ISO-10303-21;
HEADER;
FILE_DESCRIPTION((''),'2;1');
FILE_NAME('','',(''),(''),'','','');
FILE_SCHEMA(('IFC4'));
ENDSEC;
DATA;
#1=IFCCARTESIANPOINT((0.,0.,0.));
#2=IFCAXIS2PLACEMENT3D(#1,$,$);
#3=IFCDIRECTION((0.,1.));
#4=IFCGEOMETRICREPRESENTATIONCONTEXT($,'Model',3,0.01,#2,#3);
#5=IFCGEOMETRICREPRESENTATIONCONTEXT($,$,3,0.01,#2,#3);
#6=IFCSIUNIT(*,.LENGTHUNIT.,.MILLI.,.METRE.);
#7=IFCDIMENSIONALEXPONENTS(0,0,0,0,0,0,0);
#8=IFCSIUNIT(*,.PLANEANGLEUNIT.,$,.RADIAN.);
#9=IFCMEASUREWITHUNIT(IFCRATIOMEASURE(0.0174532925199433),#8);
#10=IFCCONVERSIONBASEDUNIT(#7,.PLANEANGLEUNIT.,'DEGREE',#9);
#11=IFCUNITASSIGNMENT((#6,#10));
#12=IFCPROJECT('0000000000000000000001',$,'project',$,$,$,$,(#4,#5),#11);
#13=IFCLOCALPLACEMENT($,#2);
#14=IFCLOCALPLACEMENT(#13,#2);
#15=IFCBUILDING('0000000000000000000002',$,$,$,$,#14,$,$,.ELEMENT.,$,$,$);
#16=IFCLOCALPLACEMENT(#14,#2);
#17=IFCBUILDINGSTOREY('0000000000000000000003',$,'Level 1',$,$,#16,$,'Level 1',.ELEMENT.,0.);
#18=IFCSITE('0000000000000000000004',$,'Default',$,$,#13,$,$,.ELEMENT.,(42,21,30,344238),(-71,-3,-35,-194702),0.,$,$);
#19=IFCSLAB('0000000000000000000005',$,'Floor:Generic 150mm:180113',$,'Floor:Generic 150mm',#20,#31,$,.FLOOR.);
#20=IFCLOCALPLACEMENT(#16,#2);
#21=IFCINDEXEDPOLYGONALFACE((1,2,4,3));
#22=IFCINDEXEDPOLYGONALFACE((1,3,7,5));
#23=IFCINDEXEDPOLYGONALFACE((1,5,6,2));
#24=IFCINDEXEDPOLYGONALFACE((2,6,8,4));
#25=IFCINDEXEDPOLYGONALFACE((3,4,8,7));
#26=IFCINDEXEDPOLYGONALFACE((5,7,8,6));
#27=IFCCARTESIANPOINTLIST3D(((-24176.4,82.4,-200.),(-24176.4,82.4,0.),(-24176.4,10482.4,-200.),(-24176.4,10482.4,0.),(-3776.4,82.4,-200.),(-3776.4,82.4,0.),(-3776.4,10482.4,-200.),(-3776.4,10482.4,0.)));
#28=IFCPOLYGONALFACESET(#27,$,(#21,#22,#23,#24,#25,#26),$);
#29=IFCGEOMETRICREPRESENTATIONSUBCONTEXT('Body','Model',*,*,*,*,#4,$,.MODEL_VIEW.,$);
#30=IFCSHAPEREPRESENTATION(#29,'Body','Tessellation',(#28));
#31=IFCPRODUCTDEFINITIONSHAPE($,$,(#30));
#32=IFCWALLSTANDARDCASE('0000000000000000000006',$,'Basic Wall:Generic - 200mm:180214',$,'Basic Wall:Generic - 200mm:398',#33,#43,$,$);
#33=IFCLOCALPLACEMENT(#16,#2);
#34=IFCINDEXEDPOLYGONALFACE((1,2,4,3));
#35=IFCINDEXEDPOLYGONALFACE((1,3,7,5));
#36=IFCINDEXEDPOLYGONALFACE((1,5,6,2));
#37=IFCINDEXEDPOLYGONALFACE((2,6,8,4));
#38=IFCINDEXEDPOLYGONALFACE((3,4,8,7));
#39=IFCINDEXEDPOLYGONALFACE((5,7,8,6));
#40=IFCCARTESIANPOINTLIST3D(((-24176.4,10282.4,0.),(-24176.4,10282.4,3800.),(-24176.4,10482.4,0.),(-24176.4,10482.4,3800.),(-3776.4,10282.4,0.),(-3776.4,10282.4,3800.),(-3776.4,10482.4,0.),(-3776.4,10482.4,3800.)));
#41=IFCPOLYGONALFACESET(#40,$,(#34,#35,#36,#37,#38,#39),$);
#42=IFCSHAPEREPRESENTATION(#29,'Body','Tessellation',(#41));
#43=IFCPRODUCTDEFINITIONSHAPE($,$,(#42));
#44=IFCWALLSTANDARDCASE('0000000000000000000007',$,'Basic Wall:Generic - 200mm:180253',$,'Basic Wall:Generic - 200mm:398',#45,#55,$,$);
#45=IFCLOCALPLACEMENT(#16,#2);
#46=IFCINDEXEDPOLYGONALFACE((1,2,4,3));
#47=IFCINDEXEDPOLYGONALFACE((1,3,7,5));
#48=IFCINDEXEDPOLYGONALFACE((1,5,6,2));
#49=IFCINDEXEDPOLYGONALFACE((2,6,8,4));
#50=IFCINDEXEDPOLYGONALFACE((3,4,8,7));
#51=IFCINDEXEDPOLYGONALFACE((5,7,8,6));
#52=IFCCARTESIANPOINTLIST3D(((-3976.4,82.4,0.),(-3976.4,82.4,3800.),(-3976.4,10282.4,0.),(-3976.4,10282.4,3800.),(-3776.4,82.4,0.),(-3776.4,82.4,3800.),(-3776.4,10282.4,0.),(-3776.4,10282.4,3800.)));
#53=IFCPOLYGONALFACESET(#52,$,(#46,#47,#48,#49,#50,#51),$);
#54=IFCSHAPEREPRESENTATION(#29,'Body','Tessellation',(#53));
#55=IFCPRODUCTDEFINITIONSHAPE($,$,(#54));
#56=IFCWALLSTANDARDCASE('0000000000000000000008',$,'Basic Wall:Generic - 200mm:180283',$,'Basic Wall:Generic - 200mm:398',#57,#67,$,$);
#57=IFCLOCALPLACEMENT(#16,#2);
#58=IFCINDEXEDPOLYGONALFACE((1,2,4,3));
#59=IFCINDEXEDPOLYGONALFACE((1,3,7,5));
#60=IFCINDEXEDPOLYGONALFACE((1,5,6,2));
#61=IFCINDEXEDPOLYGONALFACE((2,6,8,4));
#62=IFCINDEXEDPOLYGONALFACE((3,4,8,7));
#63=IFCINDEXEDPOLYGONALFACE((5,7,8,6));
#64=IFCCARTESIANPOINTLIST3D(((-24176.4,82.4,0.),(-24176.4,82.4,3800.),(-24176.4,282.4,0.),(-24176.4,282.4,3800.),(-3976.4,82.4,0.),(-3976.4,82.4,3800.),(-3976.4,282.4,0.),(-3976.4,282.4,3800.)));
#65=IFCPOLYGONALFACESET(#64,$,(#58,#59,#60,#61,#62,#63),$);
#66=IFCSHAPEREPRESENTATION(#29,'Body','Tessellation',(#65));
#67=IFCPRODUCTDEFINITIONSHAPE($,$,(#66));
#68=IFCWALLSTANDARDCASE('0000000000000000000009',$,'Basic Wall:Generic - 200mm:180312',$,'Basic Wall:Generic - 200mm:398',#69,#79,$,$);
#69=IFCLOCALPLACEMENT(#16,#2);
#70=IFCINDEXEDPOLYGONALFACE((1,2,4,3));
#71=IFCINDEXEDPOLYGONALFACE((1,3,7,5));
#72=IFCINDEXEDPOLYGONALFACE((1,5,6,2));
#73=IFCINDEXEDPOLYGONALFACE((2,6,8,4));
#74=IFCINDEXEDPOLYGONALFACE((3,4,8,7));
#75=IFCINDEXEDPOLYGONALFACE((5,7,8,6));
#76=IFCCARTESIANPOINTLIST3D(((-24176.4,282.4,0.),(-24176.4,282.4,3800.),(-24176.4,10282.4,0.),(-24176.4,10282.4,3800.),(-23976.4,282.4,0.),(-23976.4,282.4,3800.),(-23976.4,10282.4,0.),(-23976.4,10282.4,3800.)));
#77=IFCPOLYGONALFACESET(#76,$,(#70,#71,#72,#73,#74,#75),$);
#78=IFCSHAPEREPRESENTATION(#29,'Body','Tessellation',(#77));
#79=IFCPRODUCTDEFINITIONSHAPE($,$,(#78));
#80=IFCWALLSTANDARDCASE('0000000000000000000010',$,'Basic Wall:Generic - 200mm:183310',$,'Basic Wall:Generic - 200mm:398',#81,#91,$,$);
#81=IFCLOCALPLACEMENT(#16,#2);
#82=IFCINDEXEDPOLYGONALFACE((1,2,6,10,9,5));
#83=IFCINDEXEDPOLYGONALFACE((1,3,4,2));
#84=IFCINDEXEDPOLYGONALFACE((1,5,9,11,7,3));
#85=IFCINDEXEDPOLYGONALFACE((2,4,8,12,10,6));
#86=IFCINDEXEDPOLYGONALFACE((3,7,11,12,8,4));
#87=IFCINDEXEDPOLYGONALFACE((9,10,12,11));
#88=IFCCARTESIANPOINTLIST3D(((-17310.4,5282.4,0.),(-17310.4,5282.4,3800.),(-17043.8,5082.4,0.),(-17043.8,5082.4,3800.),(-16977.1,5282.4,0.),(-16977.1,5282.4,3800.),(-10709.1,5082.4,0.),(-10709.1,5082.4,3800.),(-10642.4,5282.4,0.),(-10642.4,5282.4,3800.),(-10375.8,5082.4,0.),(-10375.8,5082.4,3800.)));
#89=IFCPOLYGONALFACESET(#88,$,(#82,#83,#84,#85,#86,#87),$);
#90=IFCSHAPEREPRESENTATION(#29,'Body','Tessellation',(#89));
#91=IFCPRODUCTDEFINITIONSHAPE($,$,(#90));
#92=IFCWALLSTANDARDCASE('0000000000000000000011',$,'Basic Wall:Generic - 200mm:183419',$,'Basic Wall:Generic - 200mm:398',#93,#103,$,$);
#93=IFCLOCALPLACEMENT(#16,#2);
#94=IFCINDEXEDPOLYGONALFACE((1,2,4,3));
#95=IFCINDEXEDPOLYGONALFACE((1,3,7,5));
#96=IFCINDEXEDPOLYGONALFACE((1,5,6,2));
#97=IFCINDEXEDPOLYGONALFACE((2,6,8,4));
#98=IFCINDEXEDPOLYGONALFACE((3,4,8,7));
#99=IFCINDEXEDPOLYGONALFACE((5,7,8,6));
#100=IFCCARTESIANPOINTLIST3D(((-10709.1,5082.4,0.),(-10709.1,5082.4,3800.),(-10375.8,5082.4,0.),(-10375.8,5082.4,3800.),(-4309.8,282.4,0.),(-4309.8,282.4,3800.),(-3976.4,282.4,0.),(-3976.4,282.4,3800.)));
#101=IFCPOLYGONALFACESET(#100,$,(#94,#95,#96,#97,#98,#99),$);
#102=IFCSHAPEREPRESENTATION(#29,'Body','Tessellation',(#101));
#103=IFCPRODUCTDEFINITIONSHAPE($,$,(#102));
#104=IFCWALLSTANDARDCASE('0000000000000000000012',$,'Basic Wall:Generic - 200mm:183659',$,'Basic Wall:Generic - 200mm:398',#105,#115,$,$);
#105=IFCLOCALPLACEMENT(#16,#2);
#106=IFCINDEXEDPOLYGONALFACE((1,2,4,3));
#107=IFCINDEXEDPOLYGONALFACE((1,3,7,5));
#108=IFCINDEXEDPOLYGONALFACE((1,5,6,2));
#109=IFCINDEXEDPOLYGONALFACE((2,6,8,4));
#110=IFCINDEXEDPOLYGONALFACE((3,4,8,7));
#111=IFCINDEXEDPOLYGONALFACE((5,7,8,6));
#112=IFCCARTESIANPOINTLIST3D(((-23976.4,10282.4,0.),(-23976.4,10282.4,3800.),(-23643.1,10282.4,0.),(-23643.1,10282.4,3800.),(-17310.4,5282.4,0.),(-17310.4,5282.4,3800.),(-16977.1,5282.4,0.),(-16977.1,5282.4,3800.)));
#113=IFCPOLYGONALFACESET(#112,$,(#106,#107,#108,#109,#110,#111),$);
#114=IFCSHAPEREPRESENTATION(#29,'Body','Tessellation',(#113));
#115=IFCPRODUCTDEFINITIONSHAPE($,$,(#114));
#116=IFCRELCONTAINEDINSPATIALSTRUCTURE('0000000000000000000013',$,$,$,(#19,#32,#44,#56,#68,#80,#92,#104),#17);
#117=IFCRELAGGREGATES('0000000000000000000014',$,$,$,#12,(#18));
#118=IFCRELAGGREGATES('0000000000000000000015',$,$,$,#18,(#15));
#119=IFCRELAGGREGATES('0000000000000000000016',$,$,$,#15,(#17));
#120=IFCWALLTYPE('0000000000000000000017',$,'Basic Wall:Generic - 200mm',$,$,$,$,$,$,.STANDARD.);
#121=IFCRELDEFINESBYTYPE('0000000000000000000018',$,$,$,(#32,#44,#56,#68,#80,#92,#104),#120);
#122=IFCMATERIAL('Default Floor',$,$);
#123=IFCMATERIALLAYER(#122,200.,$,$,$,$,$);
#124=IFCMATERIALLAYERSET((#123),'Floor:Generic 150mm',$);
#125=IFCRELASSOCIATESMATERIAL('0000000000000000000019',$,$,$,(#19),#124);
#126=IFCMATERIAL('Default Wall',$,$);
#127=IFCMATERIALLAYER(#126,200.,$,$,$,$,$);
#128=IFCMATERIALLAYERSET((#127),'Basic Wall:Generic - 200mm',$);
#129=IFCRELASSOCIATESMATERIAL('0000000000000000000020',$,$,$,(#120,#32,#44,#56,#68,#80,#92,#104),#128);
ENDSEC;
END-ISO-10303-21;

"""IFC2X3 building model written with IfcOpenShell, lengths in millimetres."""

from ifc_helpers import new_model, entity, si_unit, converted_unit, direction, frame, frame_2d, origin, origin_2d_with_axis, place, context, subcontext, project, spatial, polyline, rectangle, outline, extrude, material, layer, layer_set, layer_usage, type_object, element, save


model = new_model("IFC2X3")

# Units and contexts
model_context = context("Model", 3, precision=0.01, world=origin(), true_north=direction((0.0, 1.0)))
context_of_model = context(None, 3, precision=0.01, world=origin(), true_north=direction((0.0, 1.0)))
body_context = subcontext(model_context, "Body", "Model", "MODEL_VIEW")
ifc_project = project(units=[si_unit("LENGTHUNIT", "METRE", prefix="MILLI"), converted_unit("PLANEANGLEUNIT", "DEGREE", entity("IfcRatioMeasure", 0.0174532925199433), si_unit("PLANEANGLEUNIT", "RADIAN"), dimensions=[0, 0, 0, 0, 0, 0, 0])], contexts=[model_context, context_of_model])

# Site, building, storey
site_placement = place(None, origin())
site = spatial("IfcSite", under=ifc_project, at=site_placement, Name="Default", CompositionType="ELEMENT", RefLatitude=(42, 21, 30, 344238), RefLongitude=(-71, -3, -35, -194702), RefElevation=0.0)
building_placement = place(site_placement, origin())
building = spatial("IfcBuilding", under=site, at=building_placement, CompositionType="ELEMENT")
storey_placement = place(building_placement, origin())
storey = spatial("IfcBuildingStorey", under=building, at=storey_placement, Name="Level 1", LongName="Level 1", CompositionType="ELEMENT", Elevation=0.0)

# Slab
ifc_material_1 = material(Name="Default Floor")
ifc_layer_1 = layer(ifc_material_1, 200.0)
ifc_layer_set_1 = layer_set([ifc_layer_1], Name="Floor:Generic 150mm")
ifc_layer_usage_1 = layer_usage(ifc_layer_set_1, "AXIS3", "POSITIVE", 0.0)
slab_placement = place(storey_placement, origin())
element("IfcSlab", 1, at=slab_placement, inside=storey, material=ifc_layer_usage_1, Name="Floor:Generic 150mm:180113", ObjectType="Floor:Generic 150mm", PredefinedType="FLOOR", context=body_context, shape_type="SweptSolid", body=[
    extrude(rectangle(XDim=10400.0, YDim=20400.0, at=origin_2d_with_axis()), frame((-13976.4, 5282.4, 0.0), z_axis=(0.0, 0.0, -1.0), x_axis=(0.0, 1.0, 0.0)), (0.0, 0.0, 1.0), 200.0),
])

# Walls
ifc_material_2 = material(Name="Default Wall")
ifc_layer_2 = layer(ifc_material_2, 200.0)
ifc_layer_set_2 = layer_set([ifc_layer_2], Name="Basic Wall:Generic - 200mm")
ifc_layer_usage_2 = layer_usage(ifc_layer_set_2, "AXIS2", "NEGATIVE", 100.0)
wall_type = type_object("IfcWallType", Name="Basic Wall:Generic - 200mm", PredefinedType="STANDARD", material=ifc_layer_set_2)
wall_1_placement = place(storey_placement, frame((-24176.4, 10382.4, 0.0)))
element("IfcWallStandardCase", 2, at=wall_1_placement, inside=storey, type_object=wall_type, material=ifc_layer_usage_2, Name="Basic Wall:Generic - 200mm:180214", ObjectType="Basic Wall:Generic - 200mm:398", context=body_context, shape_type="SweptSolid", body=[
    extrude(rectangle(XDim=20400.0, YDim=200.0, at=frame_2d((10200.0, 0.0), x_axis=(-1.0, 0.0))), origin(), (0.0, 0.0, 1.0), 3800.0),
])
ifc_layer_usage_3 = layer_usage(ifc_layer_set_2, "AXIS2", "NEGATIVE", 100.0)
wall_2_placement = place(storey_placement, frame((-3876.4, 10282.4, 0.0), z_axis=(0.0, 0.0, 1.0), x_axis=(0.0, -1.0, 0.0)))
element("IfcWallStandardCase", 3, at=wall_2_placement, inside=storey, type_object=wall_type, material=ifc_layer_usage_3, Name="Basic Wall:Generic - 200mm:180253", ObjectType="Basic Wall:Generic - 200mm:398", context=body_context, shape_type="SweptSolid", body=[
    extrude(rectangle(XDim=10200.0, YDim=200.0, at=frame_2d((5100.0, 0.0), x_axis=(-1.0, 0.0))), origin(), (0.0, 0.0, 1.0), 3800.0),
])
ifc_layer_usage_4 = layer_usage(ifc_layer_set_2, "AXIS2", "NEGATIVE", 100.0)
wall_3_placement = place(storey_placement, frame((-3976.4, 182.4, 0.0), z_axis=(0.0, 0.0, 1.0), x_axis=(-1.0, 0.0, 0.0)))
element("IfcWallStandardCase", 4, at=wall_3_placement, inside=storey, type_object=wall_type, material=ifc_layer_usage_4, Name="Basic Wall:Generic - 200mm:180283", ObjectType="Basic Wall:Generic - 200mm:398", context=body_context, shape_type="SweptSolid", body=[
    extrude(rectangle(XDim=20200.0, YDim=200.0, at=frame_2d((10100.0, 0.0), x_axis=(-1.0, 0.0))), origin(), (0.0, 0.0, 1.0), 3800.0),
])
ifc_layer_usage_5 = layer_usage(ifc_layer_set_2, "AXIS2", "NEGATIVE", 100.0)
wall_4_placement = place(storey_placement, frame((-24076.4, 282.4, 0.0), z_axis=(0.0, 0.0, 1.0), x_axis=(0.0, 1.0, 0.0)))
element("IfcWallStandardCase", 5, at=wall_4_placement, inside=storey, type_object=wall_type, material=ifc_layer_usage_5, Name="Basic Wall:Generic - 200mm:180312", ObjectType="Basic Wall:Generic - 200mm:398", context=body_context, shape_type="SweptSolid", body=[
    extrude(rectangle(XDim=10000.0, YDim=200.0, at=frame_2d((5000.0, 0.0), x_axis=(-1.0, 0.0))), origin(), (0.0, 0.0, 1.0), 3800.0),
])
ifc_layer_usage_6 = layer_usage(ifc_layer_set_2, "AXIS2", "NEGATIVE", 100.0)
wall_5_placement = place(storey_placement, frame((-17310.4, 5182.4, 0.0)))
element("IfcWallStandardCase", 6, at=wall_5_placement, inside=storey, type_object=wall_type, material=ifc_layer_usage_6, Name="Basic Wall:Generic - 200mm:183310", ObjectType="Basic Wall:Generic - 200mm:398", context=body_context, shape_type="SweptSolid", body=[
    extrude(outline(polyline([(6934.6, -100.0), (6668.0, 100.0), (333.3, 100.0), (0.0, 100.0), (266.6, -100.0), (6601.3, -100.0), (6934.6, -100.0)])), origin(), (0.0, 0.0, 1.0), 3800.0),
])
ifc_layer_usage_7 = layer_usage(ifc_layer_set_2, "AXIS2", "NEGATIVE", 100.0)
wall_6_placement = place(storey_placement, frame((-10649.1, 5162.4, 0.0), z_axis=(0.0, 0.0, 1.0), x_axis=(0.799971, -0.600038, 0.0)))
element("IfcWallStandardCase", 7, at=wall_6_placement, inside=storey, type_object=wall_type, material=ifc_layer_usage_7, Name="Basic Wall:Generic - 200mm:183419", ObjectType="Basic Wall:Generic - 200mm:398", context=body_context, shape_type="SweptSolid", body=[
    extrude(outline(polyline([(7999.5, -100.0), (8266.1, 100.0), (266.6, 100.0), (0.0, -100.0), (7999.5, -100.0)])), origin(), (0.0, 0.0, 1.0), 3800.0),
])
ifc_layer_usage_8 = layer_usage(ifc_layer_set_2, "AXIS2", "NEGATIVE", 100.0)
wall_7_placement = place(storey_placement, frame((-17037.1, 5202.4, 0.0), z_axis=(0.0, 0.0, 1.0), x_axis=(-0.799971, 0.600038, 0.0)))
element("IfcWallStandardCase", 8, at=wall_7_placement, inside=storey, type_object=wall_type, material=ifc_layer_usage_8, Name="Basic Wall:Generic - 200mm:183659", ObjectType="Basic Wall:Generic - 200mm:398", context=body_context, shape_type="SweptSolid", body=[
    extrude(outline(polyline([(8332.8, -100.0), (8599.4, 100.0), (266.6, 100.0), (0.0, -100.0), (8332.8, -100.0)])), origin(), (0.0, 0.0, 1.0), 3800.0),
])

save(model, "model.ifc")
